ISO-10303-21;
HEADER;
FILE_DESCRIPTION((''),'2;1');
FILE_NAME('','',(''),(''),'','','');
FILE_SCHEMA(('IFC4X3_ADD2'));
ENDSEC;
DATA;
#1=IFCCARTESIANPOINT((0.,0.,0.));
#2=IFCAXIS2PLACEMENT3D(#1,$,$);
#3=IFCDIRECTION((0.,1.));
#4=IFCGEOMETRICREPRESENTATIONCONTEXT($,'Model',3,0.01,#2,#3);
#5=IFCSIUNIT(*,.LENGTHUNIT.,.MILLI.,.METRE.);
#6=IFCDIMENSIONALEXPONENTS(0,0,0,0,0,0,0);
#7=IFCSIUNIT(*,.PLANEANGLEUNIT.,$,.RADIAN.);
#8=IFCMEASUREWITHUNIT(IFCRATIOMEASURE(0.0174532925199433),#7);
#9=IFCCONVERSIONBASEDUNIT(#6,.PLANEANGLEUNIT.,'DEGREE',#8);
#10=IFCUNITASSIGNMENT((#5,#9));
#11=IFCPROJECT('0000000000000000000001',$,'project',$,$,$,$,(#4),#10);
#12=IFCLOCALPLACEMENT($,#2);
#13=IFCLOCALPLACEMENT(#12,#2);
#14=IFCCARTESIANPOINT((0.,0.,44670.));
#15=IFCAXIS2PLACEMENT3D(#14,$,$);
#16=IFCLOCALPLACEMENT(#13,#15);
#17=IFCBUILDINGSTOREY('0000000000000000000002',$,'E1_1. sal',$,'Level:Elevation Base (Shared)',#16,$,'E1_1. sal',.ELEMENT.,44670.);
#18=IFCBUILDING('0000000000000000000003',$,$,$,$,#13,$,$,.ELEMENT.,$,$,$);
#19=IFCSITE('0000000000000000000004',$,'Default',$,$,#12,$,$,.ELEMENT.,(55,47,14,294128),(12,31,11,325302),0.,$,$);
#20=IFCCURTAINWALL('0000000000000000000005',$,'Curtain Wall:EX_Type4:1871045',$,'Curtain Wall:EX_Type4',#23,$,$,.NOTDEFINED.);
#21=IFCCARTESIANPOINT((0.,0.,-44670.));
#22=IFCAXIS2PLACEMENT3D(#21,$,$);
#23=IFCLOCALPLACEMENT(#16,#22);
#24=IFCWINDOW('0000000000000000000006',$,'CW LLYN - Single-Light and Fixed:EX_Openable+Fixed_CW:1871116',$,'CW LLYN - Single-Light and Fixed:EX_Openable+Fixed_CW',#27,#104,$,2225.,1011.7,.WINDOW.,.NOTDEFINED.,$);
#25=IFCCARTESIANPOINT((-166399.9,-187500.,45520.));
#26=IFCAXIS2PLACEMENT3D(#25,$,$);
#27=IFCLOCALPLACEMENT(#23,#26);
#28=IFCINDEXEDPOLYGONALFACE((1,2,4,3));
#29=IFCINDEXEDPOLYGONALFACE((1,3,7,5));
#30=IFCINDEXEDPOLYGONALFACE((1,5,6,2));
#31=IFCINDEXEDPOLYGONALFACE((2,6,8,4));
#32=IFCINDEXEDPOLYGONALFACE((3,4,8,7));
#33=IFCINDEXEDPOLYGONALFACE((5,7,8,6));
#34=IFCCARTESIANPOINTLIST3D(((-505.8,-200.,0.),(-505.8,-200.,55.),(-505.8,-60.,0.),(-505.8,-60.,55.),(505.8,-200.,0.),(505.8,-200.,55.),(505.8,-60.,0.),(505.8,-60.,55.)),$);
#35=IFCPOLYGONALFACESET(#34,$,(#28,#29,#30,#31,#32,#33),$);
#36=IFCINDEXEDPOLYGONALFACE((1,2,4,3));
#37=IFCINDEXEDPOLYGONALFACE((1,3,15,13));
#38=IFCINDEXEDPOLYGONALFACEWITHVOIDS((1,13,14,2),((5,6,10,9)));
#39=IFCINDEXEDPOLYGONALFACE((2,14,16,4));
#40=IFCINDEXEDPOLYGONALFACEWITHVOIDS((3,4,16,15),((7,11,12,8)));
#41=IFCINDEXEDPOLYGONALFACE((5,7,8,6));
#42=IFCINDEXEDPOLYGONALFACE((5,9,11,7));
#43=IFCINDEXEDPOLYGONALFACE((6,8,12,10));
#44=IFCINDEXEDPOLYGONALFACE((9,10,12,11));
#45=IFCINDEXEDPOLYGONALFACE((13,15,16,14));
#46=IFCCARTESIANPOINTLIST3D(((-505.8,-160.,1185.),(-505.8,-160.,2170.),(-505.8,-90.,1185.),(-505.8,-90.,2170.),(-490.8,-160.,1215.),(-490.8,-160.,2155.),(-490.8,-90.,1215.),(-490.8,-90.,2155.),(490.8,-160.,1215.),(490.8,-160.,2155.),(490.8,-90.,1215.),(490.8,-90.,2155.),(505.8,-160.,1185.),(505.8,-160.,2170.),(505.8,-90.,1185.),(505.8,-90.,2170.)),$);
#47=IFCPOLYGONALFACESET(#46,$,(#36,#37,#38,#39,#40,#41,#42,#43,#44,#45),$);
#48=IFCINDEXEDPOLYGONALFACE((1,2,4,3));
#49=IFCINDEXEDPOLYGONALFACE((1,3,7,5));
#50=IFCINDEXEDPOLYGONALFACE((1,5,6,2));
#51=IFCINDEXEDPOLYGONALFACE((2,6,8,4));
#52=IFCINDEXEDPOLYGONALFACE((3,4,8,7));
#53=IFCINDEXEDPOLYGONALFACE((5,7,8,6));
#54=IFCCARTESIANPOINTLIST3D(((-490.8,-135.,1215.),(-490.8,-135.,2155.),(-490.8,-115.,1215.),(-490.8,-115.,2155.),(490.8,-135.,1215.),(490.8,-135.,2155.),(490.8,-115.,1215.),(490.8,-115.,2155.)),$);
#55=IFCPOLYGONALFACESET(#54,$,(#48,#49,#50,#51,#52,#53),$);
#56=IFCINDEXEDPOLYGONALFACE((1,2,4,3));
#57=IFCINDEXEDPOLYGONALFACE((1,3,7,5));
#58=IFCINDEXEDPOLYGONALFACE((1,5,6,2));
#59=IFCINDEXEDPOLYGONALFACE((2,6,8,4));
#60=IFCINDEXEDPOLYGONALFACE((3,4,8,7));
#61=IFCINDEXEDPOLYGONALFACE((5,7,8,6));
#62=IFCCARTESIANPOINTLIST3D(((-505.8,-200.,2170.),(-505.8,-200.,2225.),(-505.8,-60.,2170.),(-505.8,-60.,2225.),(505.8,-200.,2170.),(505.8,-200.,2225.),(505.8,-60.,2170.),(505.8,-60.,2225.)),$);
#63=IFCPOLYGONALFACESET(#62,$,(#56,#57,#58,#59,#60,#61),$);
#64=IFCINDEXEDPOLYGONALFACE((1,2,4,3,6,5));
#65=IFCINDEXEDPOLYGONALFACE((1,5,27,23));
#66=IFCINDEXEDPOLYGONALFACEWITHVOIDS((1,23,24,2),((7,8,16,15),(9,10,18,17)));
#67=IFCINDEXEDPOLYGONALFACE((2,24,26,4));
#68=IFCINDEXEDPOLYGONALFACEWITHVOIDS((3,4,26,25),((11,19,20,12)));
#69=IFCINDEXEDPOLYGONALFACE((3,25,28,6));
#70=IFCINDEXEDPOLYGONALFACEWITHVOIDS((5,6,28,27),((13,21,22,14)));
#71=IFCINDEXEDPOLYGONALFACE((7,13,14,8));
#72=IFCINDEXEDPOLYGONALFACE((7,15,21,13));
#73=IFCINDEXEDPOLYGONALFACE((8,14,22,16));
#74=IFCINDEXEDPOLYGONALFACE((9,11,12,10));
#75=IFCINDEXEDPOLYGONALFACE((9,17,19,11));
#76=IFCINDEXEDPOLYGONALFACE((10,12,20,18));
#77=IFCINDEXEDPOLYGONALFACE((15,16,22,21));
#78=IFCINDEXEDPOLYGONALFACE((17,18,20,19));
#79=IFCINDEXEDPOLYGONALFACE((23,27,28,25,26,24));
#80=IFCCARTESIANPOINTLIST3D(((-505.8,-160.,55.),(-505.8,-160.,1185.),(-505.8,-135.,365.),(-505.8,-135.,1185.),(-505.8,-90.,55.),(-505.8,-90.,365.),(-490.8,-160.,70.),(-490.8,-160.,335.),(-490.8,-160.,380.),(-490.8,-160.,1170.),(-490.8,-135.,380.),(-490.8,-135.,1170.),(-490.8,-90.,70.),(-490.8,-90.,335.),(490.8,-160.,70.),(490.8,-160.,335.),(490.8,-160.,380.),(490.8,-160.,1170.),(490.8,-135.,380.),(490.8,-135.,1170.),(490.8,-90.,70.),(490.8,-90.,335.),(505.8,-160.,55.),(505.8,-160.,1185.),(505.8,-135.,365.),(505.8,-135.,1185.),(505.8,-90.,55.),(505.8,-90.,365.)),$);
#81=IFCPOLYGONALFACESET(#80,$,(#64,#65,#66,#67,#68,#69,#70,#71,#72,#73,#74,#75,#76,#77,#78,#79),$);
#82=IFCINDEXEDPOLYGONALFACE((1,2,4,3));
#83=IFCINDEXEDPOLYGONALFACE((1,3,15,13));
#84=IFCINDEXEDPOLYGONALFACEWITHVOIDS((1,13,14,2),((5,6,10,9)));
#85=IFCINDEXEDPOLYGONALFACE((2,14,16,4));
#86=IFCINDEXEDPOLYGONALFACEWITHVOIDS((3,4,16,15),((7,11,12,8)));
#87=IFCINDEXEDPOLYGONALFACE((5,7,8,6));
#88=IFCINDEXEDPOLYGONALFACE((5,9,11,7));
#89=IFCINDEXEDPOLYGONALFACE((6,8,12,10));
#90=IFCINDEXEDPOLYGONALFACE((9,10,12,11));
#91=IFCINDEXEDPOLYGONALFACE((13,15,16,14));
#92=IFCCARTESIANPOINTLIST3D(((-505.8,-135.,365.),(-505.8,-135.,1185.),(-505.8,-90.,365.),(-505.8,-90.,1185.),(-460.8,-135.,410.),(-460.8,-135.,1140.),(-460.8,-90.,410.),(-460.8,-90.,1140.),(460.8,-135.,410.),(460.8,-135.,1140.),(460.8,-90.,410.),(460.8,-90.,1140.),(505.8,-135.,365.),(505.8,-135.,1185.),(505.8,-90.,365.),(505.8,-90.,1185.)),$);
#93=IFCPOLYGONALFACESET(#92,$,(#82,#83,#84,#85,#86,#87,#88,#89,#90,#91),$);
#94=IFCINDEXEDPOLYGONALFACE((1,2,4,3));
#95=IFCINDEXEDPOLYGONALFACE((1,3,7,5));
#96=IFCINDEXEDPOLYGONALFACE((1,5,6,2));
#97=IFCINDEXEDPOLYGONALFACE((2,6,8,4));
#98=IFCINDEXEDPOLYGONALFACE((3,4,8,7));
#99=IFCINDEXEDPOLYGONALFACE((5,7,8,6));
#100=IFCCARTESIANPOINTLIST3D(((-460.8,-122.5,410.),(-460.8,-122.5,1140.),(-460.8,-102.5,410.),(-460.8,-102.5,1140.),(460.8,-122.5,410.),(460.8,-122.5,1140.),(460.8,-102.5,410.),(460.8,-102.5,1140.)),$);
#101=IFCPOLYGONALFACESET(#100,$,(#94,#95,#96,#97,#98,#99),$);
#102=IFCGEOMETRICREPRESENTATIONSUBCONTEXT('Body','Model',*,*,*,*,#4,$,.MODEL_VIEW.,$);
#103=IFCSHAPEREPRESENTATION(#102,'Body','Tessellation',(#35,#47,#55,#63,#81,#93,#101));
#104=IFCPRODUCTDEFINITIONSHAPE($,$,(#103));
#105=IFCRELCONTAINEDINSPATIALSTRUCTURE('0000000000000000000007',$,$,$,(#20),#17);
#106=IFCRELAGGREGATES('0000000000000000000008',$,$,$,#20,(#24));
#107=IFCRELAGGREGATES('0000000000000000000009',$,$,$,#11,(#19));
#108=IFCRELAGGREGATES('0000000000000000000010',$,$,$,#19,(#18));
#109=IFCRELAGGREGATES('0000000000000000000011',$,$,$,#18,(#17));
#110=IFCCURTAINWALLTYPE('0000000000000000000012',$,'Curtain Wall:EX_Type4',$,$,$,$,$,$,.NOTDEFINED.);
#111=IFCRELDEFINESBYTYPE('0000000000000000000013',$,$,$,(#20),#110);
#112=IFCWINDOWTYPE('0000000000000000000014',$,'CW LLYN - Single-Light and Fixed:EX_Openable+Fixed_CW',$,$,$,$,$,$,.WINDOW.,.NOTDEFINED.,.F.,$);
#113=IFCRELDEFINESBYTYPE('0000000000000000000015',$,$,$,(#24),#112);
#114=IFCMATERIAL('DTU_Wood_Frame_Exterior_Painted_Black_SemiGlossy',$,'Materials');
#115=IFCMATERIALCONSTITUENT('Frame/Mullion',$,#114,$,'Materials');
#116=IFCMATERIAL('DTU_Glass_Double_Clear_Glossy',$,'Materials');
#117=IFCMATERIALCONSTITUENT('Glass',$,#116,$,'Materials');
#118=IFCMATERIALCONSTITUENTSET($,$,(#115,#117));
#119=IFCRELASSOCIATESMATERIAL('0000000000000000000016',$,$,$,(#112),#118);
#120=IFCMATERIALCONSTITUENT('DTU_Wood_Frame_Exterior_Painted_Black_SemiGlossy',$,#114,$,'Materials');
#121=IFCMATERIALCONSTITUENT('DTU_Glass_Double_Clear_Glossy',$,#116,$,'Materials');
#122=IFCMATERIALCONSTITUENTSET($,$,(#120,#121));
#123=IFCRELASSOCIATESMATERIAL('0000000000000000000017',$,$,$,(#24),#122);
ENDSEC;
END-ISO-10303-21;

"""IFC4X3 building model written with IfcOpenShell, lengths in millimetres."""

from ifc_helpers import new_model, entity, si_unit, converted_unit, direction, frame, frame_2d, origin, origin_2d_with_axis, place, context, subcontext, project, spatial, polyline, rectangle, outline, extrude, source, transform, mapped, material, constituent, constituent_set, type_object, type_shapes, element, aggregate, save


model = new_model("IFC4X3")

# Units and contexts
model_context = context("Model", 3, precision=0.01, world=origin(), true_north=direction((0.0, 1.0)))
body_context = subcontext(model_context, "Body", "Model", "MODEL_VIEW")
ifc_project = project(units=[si_unit("LENGTHUNIT", "METRE", prefix="MILLI"), converted_unit("PLANEANGLEUNIT", "DEGREE", entity("IfcRatioMeasure", 0.0174532925199433), si_unit("PLANEANGLEUNIT", "RADIAN"), dimensions=[0, 0, 0, 0, 0, 0, 0])], contexts=[model_context])

# Site, building, storey
site_placement = place(None, origin())
site = spatial("IfcSite", under=ifc_project, at=site_placement, Name="Default", CompositionType="ELEMENT", RefLatitude=(55, 47, 14, 294128), RefLongitude=(12, 31, 11, 325302), RefElevation=0.0)
building_placement = place(site_placement, origin())
building = spatial("IfcBuilding", under=site, at=building_placement, CompositionType="ELEMENT")
storey_placement = place(building_placement, frame((0.0, 0.0, 44670.0)))
storey = spatial("IfcBuildingStorey", under=building, at=storey_placement, Name="E1_1. sal", ObjectType="Level:Elevation Base (Shared)", LongName="E1_1. sal", CompositionType="ELEMENT", Elevation=44670.0)

# Curtain wall
curtain_wall_type = type_object("IfcCurtainWallType", Name="Curtain Wall:EX_Type4", PredefinedType="NOTDEFINED")
curtain_wall_placement = place(storey_placement, frame((0.0, 0.0, -44670.0)))
curtain_wall = element("IfcCurtainWall", 1, at=curtain_wall_placement, inside=storey, type_object=curtain_wall_type, Name="Curtain Wall:EX_Type4:1871045", ObjectType="Curtain Wall:EX_Type4", PredefinedType="NOTDEFINED")

# Shared definitions
ifc_material_1 = material(Name="DTU_Wood_Frame_Exterior_Painted_Black_SemiGlossy", Category="Materials")
ifc_material_2 = material(Name="DTU_Glass_Double_Clear_Glossy", Category="Materials")

# Window, openings
ifc_constituent_1 = constituent(ifc_material_1, Name="DTU_Wood_Frame_Exterior_Painted_Black_SemiGlossy", Category="Materials")
ifc_constituent_2 = constituent(ifc_material_2, Name="DTU_Glass_Double_Clear_Glossy", Category="Materials")
ifc_constituent_set_1 = constituent_set(constituents=[ifc_constituent_1, ifc_constituent_2])
ifc_constituent_3 = constituent(ifc_material_1, Name="Frame/Mullion", Category="Materials")
ifc_constituent_4 = constituent(ifc_material_2, Name="Glass", Category="Materials")
ifc_constituent_set_2 = constituent_set(constituents=[ifc_constituent_3, ifc_constituent_4])
window_type_1 = type_object("IfcWindowType", Name="CW LLYN - Single-Light and Fixed:EX_Openable+Fixed_CW", ParameterTakesPrecedence=False, PartitioningType="NOTDEFINED", PredefinedType="WINDOW", material=ifc_constituent_set_2)
shared_shape_1 = source(origin(), body_context, "Body", "SweptSolid", [
    extrude(rectangle(XDim=140.0, YDim=1011.7, at=origin_2d_with_axis()), frame((0.0, -130.0, 0.0), z_axis=(0.0, 0.0, 1.0), x_axis=(0.0, -1.0, 0.0)), (0.0, 0.0, 1.0), 55.0),
    extrude(outline(polyline([(-492.5, -505.8), (492.5, -505.8), (492.5, 505.8), (-492.5, 505.8), (-492.5, -505.8)]), holes=[polyline([(477.5, -490.8), (-462.5, -490.8), (-462.5, 490.8), (477.5, 490.8), (477.5, -490.8)])]), frame((0.0, -90.0, 1677.5), z_axis=(0.0, -1.0, 0.0), x_axis=(0.0, 0.0, 1.0)), (0.0, 0.0, 1.0), 70.0),
    extrude(rectangle(XDim=981.7, YDim=20.0, at=frame_2d((0.0, 0.0), x_axis=(1.0, 0.0))), frame((0.0, -125.0, 1215.0), z_axis=(0.0, 0.0, 1.0), x_axis=(-1.0, 0.0, 0.0)), (0.0, 0.0, 1.0), 940.0),
    extrude(rectangle(XDim=981.7, YDim=20.0, at=frame_2d((0.0, 0.0), x_axis=(1.0, 0.0))), frame((0.0, -125.0, 70.0), z_axis=(0.0, 0.0, 1.0), x_axis=(-1.0, 0.0, 0.0)), (0.0, 0.0, 1.0), 265.0),
    extrude(rectangle(XDim=140.0, YDim=1011.7, at=frame_2d((0.0, 0.0), x_axis=(1.0, 0.0))), frame((0.0, -130.0, 2170.0), z_axis=(0.0, 0.0, 1.0), x_axis=(0.0, -1.0, 0.0)), (0.0, 0.0, 1.0), 55.0),
    extrude(outline(polyline([(-38.3, -480.0), (31.7, -480.0), (31.7, 650.0), (6.7, 650.0), (6.7, -170.0), (-38.3, -170.0), (-38.3, -480.0)])), frame((505.8, -128.3, 535.0), z_axis=(-1.0, 0.0, 0.0), x_axis=(0.0, -1.0, 0.0)), (0.0, 0.0, 1.0), 1011.7),
    extrude(outline(polyline([(-410.0, -505.8), (410.0, -505.8), (410.0, 505.8), (-410.0, 505.8), (-410.0, -505.8)]), holes=[polyline([(-365.0, 460.8), (365.0, 460.8), (365.0, -460.8), (-365.0, -460.8), (-365.0, 460.8)])]), frame((0.0, -90.0, 775.0), z_axis=(0.0, -1.0, 0.0), x_axis=(0.0, 0.0, 1.0)), (0.0, 0.0, 1.0), 45.0),
    extrude(rectangle(XDim=921.7, YDim=20.0, at=frame_2d((0.0, 0.0), x_axis=(1.0, 0.0))), frame((0.0, -112.5, 410.0), z_axis=(0.0, 0.0, 1.0), x_axis=(-1.0, 0.0, 0.0)), (0.0, 0.0, 1.0), 730.0),
])
type_shapes(window_type_1, [shared_shape_1])
window_1_placement = place(curtain_wall_placement, frame((-166399.9, -187500.0, 45520.0)))
window_1 = element("IfcWindow", 2, at=window_1_placement, type_object=window_type_1, material=ifc_constituent_set_1, Name="CW LLYN - Single-Light and Fixed:EX_Openable+Fixed_CW:1871116", ObjectType="CW LLYN - Single-Light and Fixed:EX_Openable+Fixed_CW", OverallHeight=2225.0, OverallWidth=1011.7, PartitioningType="NOTDEFINED", PredefinedType="WINDOW", context=body_context, shape_type="MappedRepresentation", body=[
    mapped(shared_shape_1, transform((0.0, 0.0, 0.0), scale=1.0)),
])
opening_1_placement = place(curtain_wall_placement, frame((-166399.9, -187500.0, 90190.0), z_axis=(0.0, 0.0, 1.0), x_axis=(-1.0, 0.0, 0.0)))
opening_1 = element("IfcOpeningElement", 3, at=opening_1_placement, cuts=window_1, PredefinedType="OPENING", context=body_context, shape_type="SweptSolid", body=[
    extrude(rectangle(XDim=265.0, YDim=981.7, at=frame_2d((0.0, 0.0), x_axis=(1.0, 0.0))), frame((0.0, 160.0, -44467.5), z_axis=(0.0, -1.0, 0.0), x_axis=(0.0, 0.0, 1.0)), (0.0, 0.0, 1.0), 70.0),
])
opening_2_placement = place(curtain_wall_placement, frame((-166399.9, -187500.0, 90190.0), z_axis=(0.0, 0.0, 1.0), x_axis=(-1.0, 0.0, 0.0)))
opening_2 = element("IfcOpeningElement", 4, at=opening_2_placement, cuts=window_1, PredefinedType="OPENING", context=body_context, shape_type="SweptSolid", body=[
    extrude(rectangle(XDim=790.0, YDim=981.7, at=frame_2d((0.0, 0.0), x_axis=(1.0, 0.0))), frame((0.0, 135.0, -43895.0), z_axis=(0.0, 1.0, 0.0), x_axis=(0.0, 0.0, 1.0)), (0.0, 0.0, 1.0), 25.0),
])
aggregate(curtain_wall, [window_1, opening_1, opening_2])

save(model, "model.ifc")
